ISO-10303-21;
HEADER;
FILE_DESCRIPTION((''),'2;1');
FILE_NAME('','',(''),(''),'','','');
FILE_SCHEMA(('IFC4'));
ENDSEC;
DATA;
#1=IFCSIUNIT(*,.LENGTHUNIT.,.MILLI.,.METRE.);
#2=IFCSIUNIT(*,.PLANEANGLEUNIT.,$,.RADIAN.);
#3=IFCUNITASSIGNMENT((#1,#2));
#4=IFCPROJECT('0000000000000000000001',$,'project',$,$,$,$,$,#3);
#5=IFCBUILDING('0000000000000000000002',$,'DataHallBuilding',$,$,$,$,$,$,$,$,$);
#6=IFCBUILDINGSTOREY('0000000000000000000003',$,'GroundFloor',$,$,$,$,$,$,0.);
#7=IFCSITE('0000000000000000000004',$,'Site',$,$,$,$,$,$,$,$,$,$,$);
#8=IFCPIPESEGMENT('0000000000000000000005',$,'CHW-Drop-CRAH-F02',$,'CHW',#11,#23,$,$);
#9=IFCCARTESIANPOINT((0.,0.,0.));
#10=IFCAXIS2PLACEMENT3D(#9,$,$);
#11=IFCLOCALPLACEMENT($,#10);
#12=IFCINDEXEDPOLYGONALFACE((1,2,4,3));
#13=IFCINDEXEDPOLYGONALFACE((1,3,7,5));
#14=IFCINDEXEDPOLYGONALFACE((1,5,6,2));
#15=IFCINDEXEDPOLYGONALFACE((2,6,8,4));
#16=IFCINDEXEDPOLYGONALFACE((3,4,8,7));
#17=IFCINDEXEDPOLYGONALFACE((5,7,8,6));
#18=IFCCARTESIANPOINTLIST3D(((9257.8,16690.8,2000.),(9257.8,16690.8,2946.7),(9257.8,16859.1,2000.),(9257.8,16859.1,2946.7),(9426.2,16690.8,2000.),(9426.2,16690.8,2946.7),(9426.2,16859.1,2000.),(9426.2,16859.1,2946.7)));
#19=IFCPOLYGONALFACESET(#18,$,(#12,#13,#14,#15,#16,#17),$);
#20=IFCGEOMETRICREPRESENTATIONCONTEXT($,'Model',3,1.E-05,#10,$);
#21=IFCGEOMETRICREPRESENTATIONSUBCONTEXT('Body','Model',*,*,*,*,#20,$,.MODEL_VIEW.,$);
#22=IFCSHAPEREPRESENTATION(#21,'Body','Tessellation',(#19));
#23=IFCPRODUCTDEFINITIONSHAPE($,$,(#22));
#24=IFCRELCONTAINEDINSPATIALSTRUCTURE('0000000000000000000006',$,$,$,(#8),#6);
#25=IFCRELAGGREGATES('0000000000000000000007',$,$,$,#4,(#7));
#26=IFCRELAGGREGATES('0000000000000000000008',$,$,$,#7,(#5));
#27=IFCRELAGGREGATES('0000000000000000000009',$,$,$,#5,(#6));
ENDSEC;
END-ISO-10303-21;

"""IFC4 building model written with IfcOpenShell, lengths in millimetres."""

from ifc_helpers import new_model, si_unit, frame, origin, place, context, subcontext, project, spatial, rectangle, extrude, element, save


model = new_model("IFC4")

# Units and contexts
model_context = context("Model", 3, precision=1e-05, world=origin())
body_context = subcontext(model_context, "Body", "Model", "MODEL_VIEW")
ifc_project = project(units=[si_unit("LENGTHUNIT", "METRE", prefix="MILLI"), si_unit("PLANEANGLEUNIT", "RADIAN")])

# Site, building, storey
site = spatial("IfcSite", under=ifc_project, Name="Site")
building = spatial("IfcBuilding", under=site, Name="DataHallBuilding")
storey = spatial("IfcBuildingStorey", under=building, Name="GroundFloor", Elevation=0.0)

# Pipe segment
pipe_segment_1_placement = place(None, origin())
element("IfcPipeSegment", 1, at=pipe_segment_1_placement, inside=storey, Name="CHW-Drop-CRAH-F02", ObjectType="CHW", context=body_context, shape_type="SweptSolid", body=[
    extrude(rectangle(XDim=168.3, YDim=168.3), frame((9342.0, 16775.0, 2000.0), z_axis=(0.0, 0.0, 1.0), x_axis=(1.0, 0.0, 0.0)), (0.0, 0.0, 1.0), 946.7),
])

save(model, "model.ifc")
